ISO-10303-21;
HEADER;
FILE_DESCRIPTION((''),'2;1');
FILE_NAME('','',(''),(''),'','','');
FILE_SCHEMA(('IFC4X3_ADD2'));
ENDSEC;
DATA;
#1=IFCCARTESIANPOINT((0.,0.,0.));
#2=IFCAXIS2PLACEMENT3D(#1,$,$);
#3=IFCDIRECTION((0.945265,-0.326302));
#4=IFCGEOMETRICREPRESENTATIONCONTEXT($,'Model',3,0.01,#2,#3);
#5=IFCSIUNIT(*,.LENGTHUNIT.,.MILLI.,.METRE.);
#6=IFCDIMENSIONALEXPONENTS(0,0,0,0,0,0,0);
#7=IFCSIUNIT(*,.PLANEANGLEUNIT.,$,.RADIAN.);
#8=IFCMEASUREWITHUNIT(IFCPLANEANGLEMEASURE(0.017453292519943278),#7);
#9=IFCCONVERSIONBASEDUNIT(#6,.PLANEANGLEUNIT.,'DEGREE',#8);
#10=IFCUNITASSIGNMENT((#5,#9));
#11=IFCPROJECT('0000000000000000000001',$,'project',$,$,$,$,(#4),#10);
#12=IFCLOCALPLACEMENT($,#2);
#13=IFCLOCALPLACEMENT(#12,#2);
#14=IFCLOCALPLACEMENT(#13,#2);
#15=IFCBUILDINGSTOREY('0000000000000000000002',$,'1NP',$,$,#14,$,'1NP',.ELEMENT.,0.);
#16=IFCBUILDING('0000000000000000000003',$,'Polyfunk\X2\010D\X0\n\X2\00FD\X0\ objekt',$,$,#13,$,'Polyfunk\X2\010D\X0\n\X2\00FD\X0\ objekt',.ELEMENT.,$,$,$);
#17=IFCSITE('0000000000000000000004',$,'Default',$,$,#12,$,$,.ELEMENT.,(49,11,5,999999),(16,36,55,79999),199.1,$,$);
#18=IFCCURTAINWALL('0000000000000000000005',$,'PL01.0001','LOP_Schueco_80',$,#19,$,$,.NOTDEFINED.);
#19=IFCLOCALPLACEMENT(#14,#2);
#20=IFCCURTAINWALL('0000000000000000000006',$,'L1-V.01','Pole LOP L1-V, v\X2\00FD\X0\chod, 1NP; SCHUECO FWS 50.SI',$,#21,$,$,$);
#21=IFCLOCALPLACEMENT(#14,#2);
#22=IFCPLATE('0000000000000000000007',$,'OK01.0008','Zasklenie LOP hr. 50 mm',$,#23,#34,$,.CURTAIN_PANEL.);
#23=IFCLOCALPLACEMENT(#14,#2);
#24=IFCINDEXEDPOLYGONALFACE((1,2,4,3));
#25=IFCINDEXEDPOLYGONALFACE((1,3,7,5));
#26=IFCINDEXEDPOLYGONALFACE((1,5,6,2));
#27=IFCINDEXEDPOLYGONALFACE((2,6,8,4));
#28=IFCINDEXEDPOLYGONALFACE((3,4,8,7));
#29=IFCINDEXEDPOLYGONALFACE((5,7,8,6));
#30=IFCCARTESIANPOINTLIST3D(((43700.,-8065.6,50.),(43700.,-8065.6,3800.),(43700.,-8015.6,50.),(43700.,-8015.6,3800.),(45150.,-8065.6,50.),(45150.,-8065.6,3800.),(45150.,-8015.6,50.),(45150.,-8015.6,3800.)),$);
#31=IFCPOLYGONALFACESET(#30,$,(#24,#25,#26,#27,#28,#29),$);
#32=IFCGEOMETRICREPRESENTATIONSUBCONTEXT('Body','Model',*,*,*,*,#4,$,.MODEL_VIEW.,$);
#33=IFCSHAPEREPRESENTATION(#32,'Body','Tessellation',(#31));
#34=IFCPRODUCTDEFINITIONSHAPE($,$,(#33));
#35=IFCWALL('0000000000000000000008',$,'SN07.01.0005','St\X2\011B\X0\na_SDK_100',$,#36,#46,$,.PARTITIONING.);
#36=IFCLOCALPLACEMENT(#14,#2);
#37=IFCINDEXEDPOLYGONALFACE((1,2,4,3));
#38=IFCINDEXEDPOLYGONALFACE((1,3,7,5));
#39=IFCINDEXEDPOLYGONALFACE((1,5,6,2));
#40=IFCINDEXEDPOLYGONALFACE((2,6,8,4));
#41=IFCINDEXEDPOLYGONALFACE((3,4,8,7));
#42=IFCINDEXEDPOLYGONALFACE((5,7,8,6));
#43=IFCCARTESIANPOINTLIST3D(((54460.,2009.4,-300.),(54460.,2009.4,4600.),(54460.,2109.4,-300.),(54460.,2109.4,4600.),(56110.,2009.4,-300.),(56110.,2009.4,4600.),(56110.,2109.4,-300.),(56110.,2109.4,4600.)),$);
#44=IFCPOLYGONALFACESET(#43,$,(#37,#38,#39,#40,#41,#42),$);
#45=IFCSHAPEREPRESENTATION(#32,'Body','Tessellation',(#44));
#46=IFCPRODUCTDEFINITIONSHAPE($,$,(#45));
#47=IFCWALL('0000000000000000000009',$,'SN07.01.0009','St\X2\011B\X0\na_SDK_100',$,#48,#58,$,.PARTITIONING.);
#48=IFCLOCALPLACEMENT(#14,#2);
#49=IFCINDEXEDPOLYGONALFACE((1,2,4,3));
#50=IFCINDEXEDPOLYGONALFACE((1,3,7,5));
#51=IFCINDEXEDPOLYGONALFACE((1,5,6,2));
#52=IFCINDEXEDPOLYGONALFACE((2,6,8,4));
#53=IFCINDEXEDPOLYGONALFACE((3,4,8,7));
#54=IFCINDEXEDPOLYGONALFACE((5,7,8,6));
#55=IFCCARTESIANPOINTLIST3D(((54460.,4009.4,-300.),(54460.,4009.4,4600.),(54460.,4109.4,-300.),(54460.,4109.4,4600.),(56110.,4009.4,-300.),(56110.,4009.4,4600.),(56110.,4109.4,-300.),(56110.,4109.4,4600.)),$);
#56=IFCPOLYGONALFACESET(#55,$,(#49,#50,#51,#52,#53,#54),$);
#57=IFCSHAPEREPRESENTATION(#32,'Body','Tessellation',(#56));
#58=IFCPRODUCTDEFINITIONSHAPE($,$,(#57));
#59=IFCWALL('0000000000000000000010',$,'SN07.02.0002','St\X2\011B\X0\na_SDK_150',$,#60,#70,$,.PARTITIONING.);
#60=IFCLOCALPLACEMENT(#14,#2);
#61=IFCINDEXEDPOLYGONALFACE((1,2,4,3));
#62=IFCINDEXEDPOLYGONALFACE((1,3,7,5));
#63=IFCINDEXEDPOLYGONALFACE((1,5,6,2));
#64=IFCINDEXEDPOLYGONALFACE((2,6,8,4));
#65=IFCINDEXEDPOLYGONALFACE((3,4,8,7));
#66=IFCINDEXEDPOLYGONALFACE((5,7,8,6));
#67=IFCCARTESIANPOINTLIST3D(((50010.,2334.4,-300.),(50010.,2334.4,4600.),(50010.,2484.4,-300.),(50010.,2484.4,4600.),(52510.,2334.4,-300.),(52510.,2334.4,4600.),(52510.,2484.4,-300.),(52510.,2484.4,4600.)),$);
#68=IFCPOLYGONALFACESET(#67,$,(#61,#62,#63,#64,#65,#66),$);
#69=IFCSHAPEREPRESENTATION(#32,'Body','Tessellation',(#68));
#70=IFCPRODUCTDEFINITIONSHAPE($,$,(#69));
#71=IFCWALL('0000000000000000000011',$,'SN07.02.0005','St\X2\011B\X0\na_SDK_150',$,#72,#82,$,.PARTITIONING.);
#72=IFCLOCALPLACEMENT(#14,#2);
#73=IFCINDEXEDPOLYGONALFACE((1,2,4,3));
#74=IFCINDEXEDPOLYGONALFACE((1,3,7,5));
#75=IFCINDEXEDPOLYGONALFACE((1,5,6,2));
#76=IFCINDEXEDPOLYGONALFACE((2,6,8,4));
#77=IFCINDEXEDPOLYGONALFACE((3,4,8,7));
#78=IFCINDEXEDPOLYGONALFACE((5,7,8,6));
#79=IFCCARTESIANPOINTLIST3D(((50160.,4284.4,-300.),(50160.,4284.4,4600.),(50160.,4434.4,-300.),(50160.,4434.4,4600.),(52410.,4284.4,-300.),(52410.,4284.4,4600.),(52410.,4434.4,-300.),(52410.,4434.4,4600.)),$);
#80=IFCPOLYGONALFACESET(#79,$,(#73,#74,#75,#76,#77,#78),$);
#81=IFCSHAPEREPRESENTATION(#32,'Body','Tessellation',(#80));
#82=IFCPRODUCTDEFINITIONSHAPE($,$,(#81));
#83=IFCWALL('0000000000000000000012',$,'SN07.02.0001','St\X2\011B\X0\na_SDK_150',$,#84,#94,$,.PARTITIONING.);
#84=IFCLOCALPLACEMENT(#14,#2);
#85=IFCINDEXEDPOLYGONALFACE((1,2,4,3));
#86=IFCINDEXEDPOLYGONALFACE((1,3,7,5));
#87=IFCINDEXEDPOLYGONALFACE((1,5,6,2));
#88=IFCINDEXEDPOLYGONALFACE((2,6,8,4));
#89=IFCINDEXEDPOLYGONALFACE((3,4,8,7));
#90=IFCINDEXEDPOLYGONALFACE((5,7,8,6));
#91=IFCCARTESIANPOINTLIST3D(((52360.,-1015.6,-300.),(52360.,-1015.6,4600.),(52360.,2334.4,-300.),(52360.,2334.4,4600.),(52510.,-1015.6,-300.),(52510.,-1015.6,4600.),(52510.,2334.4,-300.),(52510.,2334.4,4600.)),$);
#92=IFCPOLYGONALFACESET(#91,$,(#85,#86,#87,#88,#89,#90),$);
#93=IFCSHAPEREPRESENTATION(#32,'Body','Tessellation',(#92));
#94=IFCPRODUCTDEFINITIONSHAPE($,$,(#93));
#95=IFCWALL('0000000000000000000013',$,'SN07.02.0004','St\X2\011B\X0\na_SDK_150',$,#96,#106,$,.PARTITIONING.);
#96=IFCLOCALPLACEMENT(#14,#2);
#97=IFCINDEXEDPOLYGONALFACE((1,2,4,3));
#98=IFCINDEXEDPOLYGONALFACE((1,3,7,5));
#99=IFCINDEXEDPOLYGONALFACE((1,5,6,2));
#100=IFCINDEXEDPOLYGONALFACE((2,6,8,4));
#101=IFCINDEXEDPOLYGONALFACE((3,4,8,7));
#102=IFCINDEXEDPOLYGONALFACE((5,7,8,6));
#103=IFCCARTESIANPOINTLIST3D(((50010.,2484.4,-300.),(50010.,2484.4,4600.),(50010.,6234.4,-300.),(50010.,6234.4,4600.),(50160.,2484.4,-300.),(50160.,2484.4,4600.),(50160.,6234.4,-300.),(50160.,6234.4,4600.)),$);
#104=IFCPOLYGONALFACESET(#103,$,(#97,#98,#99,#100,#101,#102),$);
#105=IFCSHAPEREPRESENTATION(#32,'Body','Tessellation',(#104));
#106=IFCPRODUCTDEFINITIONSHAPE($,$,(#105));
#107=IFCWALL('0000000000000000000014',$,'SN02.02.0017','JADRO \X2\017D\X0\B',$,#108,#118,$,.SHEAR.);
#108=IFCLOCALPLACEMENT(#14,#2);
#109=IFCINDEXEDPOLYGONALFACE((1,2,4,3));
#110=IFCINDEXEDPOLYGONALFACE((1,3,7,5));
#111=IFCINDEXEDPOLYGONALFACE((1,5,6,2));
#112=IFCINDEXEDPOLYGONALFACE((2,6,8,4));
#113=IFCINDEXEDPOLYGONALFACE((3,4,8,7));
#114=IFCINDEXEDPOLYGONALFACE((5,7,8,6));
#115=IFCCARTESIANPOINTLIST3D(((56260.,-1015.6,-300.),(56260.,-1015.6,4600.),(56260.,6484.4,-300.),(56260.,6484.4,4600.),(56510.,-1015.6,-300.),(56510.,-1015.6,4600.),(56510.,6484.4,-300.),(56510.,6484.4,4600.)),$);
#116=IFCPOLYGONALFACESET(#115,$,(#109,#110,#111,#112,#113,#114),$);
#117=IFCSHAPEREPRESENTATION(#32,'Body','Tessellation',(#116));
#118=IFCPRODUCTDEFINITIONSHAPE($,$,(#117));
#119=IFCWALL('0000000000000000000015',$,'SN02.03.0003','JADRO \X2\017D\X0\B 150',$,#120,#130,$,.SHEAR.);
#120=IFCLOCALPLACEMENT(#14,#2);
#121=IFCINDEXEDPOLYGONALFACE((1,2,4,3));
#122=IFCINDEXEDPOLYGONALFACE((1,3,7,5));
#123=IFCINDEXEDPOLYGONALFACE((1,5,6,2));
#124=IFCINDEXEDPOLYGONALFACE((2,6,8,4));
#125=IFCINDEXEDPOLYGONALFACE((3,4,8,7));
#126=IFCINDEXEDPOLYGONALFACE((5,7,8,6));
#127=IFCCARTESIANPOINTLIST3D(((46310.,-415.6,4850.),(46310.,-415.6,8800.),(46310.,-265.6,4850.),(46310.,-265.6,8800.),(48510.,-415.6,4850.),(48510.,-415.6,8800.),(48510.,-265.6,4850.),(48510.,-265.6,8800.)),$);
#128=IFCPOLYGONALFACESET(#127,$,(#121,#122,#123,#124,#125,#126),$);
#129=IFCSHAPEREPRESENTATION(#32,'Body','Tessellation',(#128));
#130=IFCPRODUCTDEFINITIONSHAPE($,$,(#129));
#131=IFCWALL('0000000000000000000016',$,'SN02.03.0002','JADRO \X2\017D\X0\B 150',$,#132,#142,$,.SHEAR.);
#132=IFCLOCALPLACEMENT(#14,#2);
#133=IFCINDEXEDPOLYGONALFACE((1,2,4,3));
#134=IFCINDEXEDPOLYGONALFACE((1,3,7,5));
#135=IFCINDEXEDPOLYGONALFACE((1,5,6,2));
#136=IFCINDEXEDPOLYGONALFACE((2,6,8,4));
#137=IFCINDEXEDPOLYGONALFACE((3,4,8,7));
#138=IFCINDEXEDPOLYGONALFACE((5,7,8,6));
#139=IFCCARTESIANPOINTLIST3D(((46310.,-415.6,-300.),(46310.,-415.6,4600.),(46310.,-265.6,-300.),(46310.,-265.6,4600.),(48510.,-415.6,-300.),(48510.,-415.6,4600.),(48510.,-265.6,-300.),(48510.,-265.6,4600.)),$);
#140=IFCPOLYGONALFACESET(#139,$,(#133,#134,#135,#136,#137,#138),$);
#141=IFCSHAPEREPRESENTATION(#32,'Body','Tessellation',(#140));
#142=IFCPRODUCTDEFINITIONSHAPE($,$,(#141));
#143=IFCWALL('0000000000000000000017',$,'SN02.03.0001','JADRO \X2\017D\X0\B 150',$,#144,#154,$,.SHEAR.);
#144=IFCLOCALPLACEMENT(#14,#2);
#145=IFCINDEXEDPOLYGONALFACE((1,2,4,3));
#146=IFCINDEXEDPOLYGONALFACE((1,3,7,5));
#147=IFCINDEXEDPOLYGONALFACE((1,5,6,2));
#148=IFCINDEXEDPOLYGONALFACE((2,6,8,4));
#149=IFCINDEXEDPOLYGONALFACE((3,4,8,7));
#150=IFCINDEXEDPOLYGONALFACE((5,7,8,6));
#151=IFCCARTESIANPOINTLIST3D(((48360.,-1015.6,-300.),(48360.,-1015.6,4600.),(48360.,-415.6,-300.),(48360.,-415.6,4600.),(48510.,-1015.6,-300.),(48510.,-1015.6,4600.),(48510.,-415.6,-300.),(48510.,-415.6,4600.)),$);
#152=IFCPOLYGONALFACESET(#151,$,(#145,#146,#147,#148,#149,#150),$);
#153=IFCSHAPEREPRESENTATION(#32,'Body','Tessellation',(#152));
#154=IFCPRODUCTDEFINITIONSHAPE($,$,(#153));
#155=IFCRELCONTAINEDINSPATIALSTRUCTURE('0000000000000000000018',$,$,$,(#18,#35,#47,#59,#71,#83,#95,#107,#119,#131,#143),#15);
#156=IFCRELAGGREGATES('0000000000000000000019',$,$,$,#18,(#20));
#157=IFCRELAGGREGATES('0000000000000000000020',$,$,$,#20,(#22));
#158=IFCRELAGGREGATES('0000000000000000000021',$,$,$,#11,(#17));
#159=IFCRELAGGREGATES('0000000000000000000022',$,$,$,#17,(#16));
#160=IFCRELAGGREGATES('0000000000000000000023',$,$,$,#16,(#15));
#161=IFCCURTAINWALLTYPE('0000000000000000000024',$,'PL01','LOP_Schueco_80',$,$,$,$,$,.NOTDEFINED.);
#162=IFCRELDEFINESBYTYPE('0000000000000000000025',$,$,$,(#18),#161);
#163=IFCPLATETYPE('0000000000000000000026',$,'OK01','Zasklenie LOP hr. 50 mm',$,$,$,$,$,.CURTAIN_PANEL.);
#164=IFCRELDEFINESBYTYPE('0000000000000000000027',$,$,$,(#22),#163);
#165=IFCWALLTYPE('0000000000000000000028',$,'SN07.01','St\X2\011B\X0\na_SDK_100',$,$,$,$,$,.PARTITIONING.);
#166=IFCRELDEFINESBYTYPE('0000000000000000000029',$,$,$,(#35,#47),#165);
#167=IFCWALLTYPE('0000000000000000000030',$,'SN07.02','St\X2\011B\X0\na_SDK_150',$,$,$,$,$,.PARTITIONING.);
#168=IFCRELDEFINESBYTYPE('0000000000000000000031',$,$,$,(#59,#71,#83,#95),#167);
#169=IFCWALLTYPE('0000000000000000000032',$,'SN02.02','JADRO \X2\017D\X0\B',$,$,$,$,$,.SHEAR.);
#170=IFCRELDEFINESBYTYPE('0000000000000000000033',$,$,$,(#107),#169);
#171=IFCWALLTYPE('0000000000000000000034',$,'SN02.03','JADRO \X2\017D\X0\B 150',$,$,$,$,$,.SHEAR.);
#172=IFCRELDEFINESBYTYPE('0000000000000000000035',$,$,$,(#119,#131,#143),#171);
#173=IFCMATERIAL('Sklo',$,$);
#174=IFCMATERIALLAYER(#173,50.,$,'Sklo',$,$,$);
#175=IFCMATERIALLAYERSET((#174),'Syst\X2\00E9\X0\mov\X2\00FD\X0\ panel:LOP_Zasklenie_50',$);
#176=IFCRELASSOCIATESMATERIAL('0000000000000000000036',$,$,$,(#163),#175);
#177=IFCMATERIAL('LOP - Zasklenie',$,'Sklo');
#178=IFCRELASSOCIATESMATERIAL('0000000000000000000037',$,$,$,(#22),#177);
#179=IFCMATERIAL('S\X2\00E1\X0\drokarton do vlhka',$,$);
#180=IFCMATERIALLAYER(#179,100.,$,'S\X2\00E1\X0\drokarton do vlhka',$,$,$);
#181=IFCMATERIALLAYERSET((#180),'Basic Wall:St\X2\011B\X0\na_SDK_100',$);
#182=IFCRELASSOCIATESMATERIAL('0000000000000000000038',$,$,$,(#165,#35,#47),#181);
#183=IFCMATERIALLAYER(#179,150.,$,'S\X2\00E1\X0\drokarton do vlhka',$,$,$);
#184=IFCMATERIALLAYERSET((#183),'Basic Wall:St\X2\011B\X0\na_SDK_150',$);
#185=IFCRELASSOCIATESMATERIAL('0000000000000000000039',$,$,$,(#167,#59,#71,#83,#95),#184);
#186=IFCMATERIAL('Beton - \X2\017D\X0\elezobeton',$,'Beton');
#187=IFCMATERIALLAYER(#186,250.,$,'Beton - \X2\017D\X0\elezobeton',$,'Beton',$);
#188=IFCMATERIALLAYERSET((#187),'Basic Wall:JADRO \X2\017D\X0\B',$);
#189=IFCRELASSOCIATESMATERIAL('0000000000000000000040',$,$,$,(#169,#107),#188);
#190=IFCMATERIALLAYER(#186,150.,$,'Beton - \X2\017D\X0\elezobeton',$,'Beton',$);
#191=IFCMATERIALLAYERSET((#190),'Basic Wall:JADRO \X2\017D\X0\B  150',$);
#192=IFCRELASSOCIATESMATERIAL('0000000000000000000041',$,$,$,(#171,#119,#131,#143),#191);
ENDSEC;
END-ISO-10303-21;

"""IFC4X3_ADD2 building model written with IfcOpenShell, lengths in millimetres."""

from ifc_helpers import new_model, entity, si_unit, converted_unit, direction, frame, frame_2d, origin, place, context, subcontext, project, spatial, polyline, rectangle, extrude, clip, bounded_halfspace, source, transform, mapped, material, layer, layer_set, type_object, type_shapes, element, aggregate, save


model = new_model("IFC4X3_ADD2")

# Units and contexts
model_context = context("Model", 3, precision=0.01, world=origin(), true_north=direction((0.945265, -0.326302)))
body_context = subcontext(model_context, "Body", "Model", "MODEL_VIEW")
ifc_project = project(units=[si_unit("LENGTHUNIT", "METRE", prefix="MILLI"), converted_unit("PLANEANGLEUNIT", "DEGREE", entity("IfcPlaneAngleMeasure", 0.017453292519943278), si_unit("PLANEANGLEUNIT", "RADIAN"), dimensions=[0, 0, 0, 0, 0, 0, 0])], contexts=[model_context])

# Site, building, storey
site_placement = place(None, origin())
site = spatial("IfcSite", under=ifc_project, at=site_placement, Name="Default", CompositionType="ELEMENT", RefLatitude=(49, 11, 5, 999999), RefLongitude=(16, 36, 55, 79999), RefElevation=199.1)
building_placement = place(site_placement, origin())
building = spatial("IfcBuilding", under=site, at=building_placement, Name="Polyfunkčný objekt", LongName="Polyfunkčný objekt", CompositionType="ELEMENT")
storey_placement = place(building_placement, origin())
storey = spatial("IfcBuildingStorey", under=building, at=storey_placement, Name="1NP", LongName="1NP", CompositionType="ELEMENT", Elevation=0.0)

# Curtain walls, plate
curtain_wall_type = type_object("IfcCurtainWallType", Name="PL01", Description="LOP_Schueco_80", PredefinedType="NOTDEFINED")
curtain_wall_1_placement = place(storey_placement, origin())
curtain_wall_1 = element("IfcCurtainWall", 1, at=curtain_wall_1_placement, inside=storey, type_object=curtain_wall_type, Name="PL01.0001", Description="LOP_Schueco_80", PredefinedType="NOTDEFINED")
curtain_wall_2 = element("IfcCurtainWall", 2, Name="L1-V.01", Description="Pole LOP L1-V, východ, 1NP; SCHUECO FWS 50.SI")
aggregate(curtain_wall_1, [curtain_wall_2])
ifc_material_1 = material(Name="LOP - Zasklenie", Category="Sklo")
ifc_material_2 = material(Name="Sklo")
ifc_layer_1 = layer(ifc_material_2, 50.0, Name="Sklo")
ifc_layer_set_1 = layer_set([ifc_layer_1], Name="Systémový panel:LOP_Zasklenie_50")
plate_type = type_object("IfcPlateType", Name="OK01", Description="Zasklenie LOP hr. 50 mm", PredefinedType="CURTAIN_PANEL", material=ifc_layer_set_1)
shared_shape_1 = source(origin(), body_context, "Body", "SweptSolid", [
    extrude(rectangle(XDim=3750.0, YDim=1450.0, at=frame_2d((-331.2, 0.0), x_axis=(1.0, 0.0))), frame((0.0, -50.0, 2206.2), z_axis=(0.0, 1.0, 0.0), x_axis=(0.0, 0.0, 1.0)), (0.0, 0.0, 1.0), 50.0),
])
type_shapes(plate_type, [shared_shape_1])
plate_placement = place(curtain_wall_1_placement, frame((44425.0, -8015.6, 50.0)))
plate = element("IfcPlate", 3, at=plate_placement, type_object=plate_type, material=ifc_material_1, Name="OK01.0008", Description="Zasklenie LOP hr. 50 mm", PredefinedType="CURTAIN_PANEL", context=body_context, shape_type="MappedRepresentation", body=[
    mapped(shared_shape_1, transform((0.0, 0.0, 0.0), scale=1.0)),
])
aggregate(curtain_wall_2, [plate])

# Walls
ifc_material_3 = material(Name="Sádrokarton do vlhka")
ifc_layer_2 = layer(ifc_material_3, 100.0, Name="Sádrokarton do vlhka")
ifc_layer_set_2 = layer_set([ifc_layer_2], Name="Basic Wall:Stěna_SDK_100")
wall_type_1 = type_object("IfcWallType", Name="SN07.01", Description="Stěna_SDK_100", PredefinedType="PARTITIONING", material=ifc_layer_set_2)
wall_1_placement = place(storey_placement, frame((54460.0, 2059.4, -300.0)))
element("IfcWall", 4, at=wall_1_placement, inside=storey, type_object=wall_type_1, material=ifc_layer_set_2, Name="SN07.01.0005", Description="Stěna_SDK_100", PredefinedType="PARTITIONING", context=body_context, shape_type="Clipping", body=[
    clip(clip(extrude(rectangle(XDim=1650.0, YDim=100.0, at=frame_2d((825.0, 0.0), x_axis=(-1.0, 0.0))), origin(), (0.0, 0.0, 1.0), 4900.0), bounded_halfspace(frame((0.0, -50.0, 4900.0), z_axis=(0.0, 0.0, -1.0), x_axis=(1.0, 0.0, 0.0)), True, frame((0.0, -50.0, 4900.0)), polyline([(0.0, 0.0), (1650.0, 0.0), (1650.0, 100.0), (0.0, 100.0), (0.0, 0.0)]))), bounded_halfspace(frame((1650.0, -50.0, 0.0), z_axis=(0.0, 0.0, 1.0), x_axis=(0.0, 1.0, 0.0)), True, frame((1650.0, -50.0, 0.0)), polyline([(0.0, 0.0), (0.0, 100.0), (-1650.0, 100.0), (-1650.0, 0.0), (0.0, 0.0)]))),
])
wall_2_placement = place(storey_placement, frame((54460.0, 4059.4, -300.0)))
element("IfcWall", 5, at=wall_2_placement, inside=storey, type_object=wall_type_1, material=ifc_layer_set_2, Name="SN07.01.0009", Description="Stěna_SDK_100", PredefinedType="PARTITIONING", context=body_context, shape_type="Clipping", body=[
    clip(clip(extrude(rectangle(XDim=1650.0, YDim=100.0, at=frame_2d((825.0, 0.0), x_axis=(-1.0, 0.0))), origin(), (0.0, 0.0, 1.0), 4900.0), bounded_halfspace(frame((0.0, -50.0, 4900.0), z_axis=(0.0, 0.0, -1.0), x_axis=(1.0, 0.0, 0.0)), True, frame((0.0, -50.0, 4900.0)), polyline([(0.0, 0.0), (1650.0, 0.0), (1650.0, 100.0), (0.0, 100.0), (0.0, 0.0)]))), bounded_halfspace(frame((1650.0, -50.0, 0.0), z_axis=(0.0, 0.0, 1.0), x_axis=(0.0, 1.0, 0.0)), True, frame((1650.0, -50.0, 0.0)), polyline([(0.0, 0.0), (0.0, 100.0), (-1650.0, 100.0), (-1650.0, 0.0), (0.0, 0.0)]))),
])
ifc_layer_3 = layer(ifc_material_3, 150.0, Name="Sádrokarton do vlhka")
ifc_layer_set_3 = layer_set([ifc_layer_3], Name="Basic Wall:Stěna_SDK_150")
wall_type_2 = type_object("IfcWallType", Name="SN07.02", Description="Stěna_SDK_150", PredefinedType="PARTITIONING", material=ifc_layer_set_3)
wall_3_placement = place(storey_placement, frame((50010.0, 2409.4, -300.0)))
element("IfcWall", 6, at=wall_3_placement, inside=storey, type_object=wall_type_2, material=ifc_layer_set_3, Name="SN07.02.0002", Description="Stěna_SDK_150", PredefinedType="PARTITIONING", context=body_context, shape_type="Clipping", body=[
    clip(clip(extrude(rectangle(XDim=2500.0, YDim=150.0, at=frame_2d((1250.0, 0.0), x_axis=(-1.0, 0.0))), origin(), (0.0, 0.0, 1.0), 4900.0), bounded_halfspace(frame((2500.0, -75.0, 0.0), z_axis=(0.0, 0.0, 1.0), x_axis=(0.0, 1.0, 0.0)), True, frame((2500.0, -75.0, 0.0)), polyline([(0.0, 0.0), (0.0, 150.0), (-100.0, 150.0), (-2350.0, 150.0), (-2500.0, 150.0), (-2500.0, 0.0), (-150.0, 0.0), (0.0, 0.0)]))), bounded_halfspace(frame((0.0, -75.0, 4900.0), z_axis=(0.0, 0.0, -1.0), x_axis=(1.0, 0.0, 0.0)), True, frame((0.0, -75.0, 4900.0)), polyline([(0.0, 0.0), (2350.0, 0.0), (2500.0, 0.0), (2500.0, 150.0), (2400.0, 150.0), (150.0, 150.0), (0.0, 150.0), (0.0, 0.0)]))),
])
wall_4_placement = place(storey_placement, frame((50160.0, 4359.4, -300.0)))
element("IfcWall", 7, at=wall_4_placement, inside=storey, type_object=wall_type_2, material=ifc_layer_set_3, Name="SN07.02.0005", Description="Stěna_SDK_150", PredefinedType="PARTITIONING", context=body_context, shape_type="Clipping", body=[
    clip(clip(extrude(rectangle(XDim=2250.0, YDim=150.0, at=frame_2d((1125.0, 0.0), x_axis=(-1.0, 0.0))), origin(), (0.0, 0.0, 1.0), 4900.0), bounded_halfspace(frame((2250.0, -75.0, 0.0), z_axis=(0.0, 0.0, 1.0), x_axis=(0.0, 1.0, 0.0)), True, frame((2250.0, -75.0, 0.0)), polyline([(0.0, 0.0), (0.0, 150.0), (-2250.0, 150.0), (-2250.0, 0.0), (0.0, 0.0)]))), bounded_halfspace(frame((0.0, -75.0, 4900.0), z_axis=(0.0, 0.0, -1.0), x_axis=(1.0, 0.0, 0.0)), True, frame((0.0, -75.0, 4900.0)), polyline([(0.0, 0.0), (2250.0, 0.0), (2250.0, 150.0), (0.0, 150.0), (0.0, 0.0)]))),
])
wall_5_placement = place(storey_placement, frame((52435.0, 2334.4, -300.0), z_axis=(0.0, 0.0, 1.0), x_axis=(0.0, -1.0, 0.0)))
element("IfcWall", 8, at=wall_5_placement, inside=storey, type_object=wall_type_2, material=ifc_layer_set_3, Name="SN07.02.0001", Description="Stěna_SDK_150", PredefinedType="PARTITIONING", context=body_context, shape_type="Clipping", body=[
    clip(clip(extrude(rectangle(XDim=3350.0, YDim=150.0, at=frame_2d((1675.0, 0.0), x_axis=(-1.0, 0.0))), origin(), (0.0, 0.0, 1.0), 4900.0), bounded_halfspace(frame((3350.0, -75.0, 0.0), z_axis=(0.0, 0.0, 1.0), x_axis=(-1.0, 0.0, 0.0)), True, frame((3350.0, -75.0, 0.0)), polyline([(0.0, 0.0), (0.0, 150.0), (-3350.0, 150.0), (-3350.0, 0.0), (0.0, 0.0)]))), bounded_halfspace(frame((0.0, -75.0, 4900.0), z_axis=(0.0, 0.0, -1.0), x_axis=(0.0, 1.0, 0.0)), True, frame((0.0, -75.0, 4900.0)), polyline([(0.0, 0.0), (3350.0, 0.0), (3350.0, 150.0), (0.0, 150.0), (0.0, 0.0)]))),
])
wall_6_placement = place(storey_placement, frame((50085.0, 2484.4, -300.0), z_axis=(0.0, 0.0, 1.0), x_axis=(0.0, 1.0, 0.0)))
element("IfcWall", 9, at=wall_6_placement, inside=storey, type_object=wall_type_2, material=ifc_layer_set_3, Name="SN07.02.0004", Description="Stěna_SDK_150", PredefinedType="PARTITIONING", context=body_context, shape_type="Clipping", body=[
    clip(clip(extrude(rectangle(XDim=3750.0, YDim=150.0, at=frame_2d((1875.0, 0.0), x_axis=(-1.0, 0.0))), origin(), (0.0, 0.0, 1.0), 4900.0), bounded_halfspace(frame((0.0, -75.0, 4900.0), z_axis=(0.0, 0.0, -1.0), x_axis=(0.0, -1.0, 0.0)), True, frame((0.0, -75.0, 4900.0)), polyline([(0.0, 0.0), (1800.0, 0.0), (1950.0, 0.0), (3750.0, 0.0), (3750.0, 150.0), (0.0, 150.0), (0.0, 0.0)]))), bounded_halfspace(frame((3750.0, -75.0, 0.0)), True, frame((3750.0, -75.0, 0.0)), polyline([(0.0, 0.0), (0.0, 150.0), (-3750.0, 150.0), (-3750.0, 0.0), (-1950.0, 0.0), (-1800.0, 0.0), (0.0, 0.0)]))),
])
ifc_material_4 = material(Name="Beton - Železobeton", Category="Beton")
ifc_layer_4 = layer(ifc_material_4, 250.0, Name="Beton - Železobeton", Category="Beton")
ifc_layer_set_4 = layer_set([ifc_layer_4], Name="Basic Wall:JADRO ŽB")
wall_type_3 = type_object("IfcWallType", Name="SN02.02", Description="JADRO ŽB", PredefinedType="SHEAR", material=ifc_layer_set_4)
wall_7_placement = place(storey_placement, frame((56385.0, -1015.6, -300.0), z_axis=(0.0, 0.0, 1.0), x_axis=(0.0, 1.0, 0.0)))
element("IfcWall", 10, at=wall_7_placement, inside=storey, type_object=wall_type_3, material=ifc_layer_set_4, Name="SN02.02.0017", Description="JADRO ŽB", PredefinedType="SHEAR", context=body_context, shape_type="Clipping", body=[
    clip(clip(extrude(rectangle(XDim=7500.0, YDim=250.0, at=frame_2d((3750.0, 0.0), x_axis=(-1.0, 0.0))), origin(), (0.0, 0.0, 1.0), 4900.0), bounded_halfspace(frame((0.0, -125.0, 4900.0), z_axis=(0.0, 0.0, -1.0), x_axis=(0.0, -1.0, 0.0)), True, frame((0.0, -125.0, 4900.0)), polyline([(0.0, 0.0), (7500.0, 0.0), (7500.0, 250.0), (7250.0, 250.0), (0.0, 250.0), (0.0, 0.0)]))), bounded_halfspace(frame((0.0, -125.0, 0.0)), True, frame((0.0, -125.0, 0.0)), polyline([(0.0, 0.0), (7110.0, 0.0), (7500.0, 0.0), (7500.0, 250.0), (7250.0, 250.0), (0.0, 250.0), (0.0, 0.0)]))),
])
ifc_layer_5 = layer(ifc_material_4, 150.0, Name="Beton - Železobeton", Category="Beton")
ifc_layer_set_5 = layer_set([ifc_layer_5], Name="Basic Wall:JADRO ŽB  150")
wall_type_4 = type_object("IfcWallType", Name="SN02.03", Description="JADRO ŽB 150", PredefinedType="SHEAR", material=ifc_layer_set_5)
wall_8_placement = place(storey_placement, frame((46310.0, -340.6, 4850.0)))
element("IfcWall", 11, at=wall_8_placement, inside=storey, type_object=wall_type_4, material=ifc_layer_set_5, Name="SN02.03.0003", Description="JADRO ŽB 150", PredefinedType="SHEAR", context=body_context, shape_type="Clipping", body=[
    clip(clip(extrude(rectangle(XDim=2200.0, YDim=150.0, at=frame_2d((1100.0, 0.0), x_axis=(-1.0, 0.0))), origin(), (0.0, 0.0, 1.0), 3950.0), bounded_halfspace(frame((2200.0, -75.0, 0.0), z_axis=(0.0, 0.0, 1.0), x_axis=(-1.0, 0.0, 0.0)), True, frame((2200.0, -75.0, 0.0)), polyline([(0.0, 0.0), (0.0, 150.0), (-2200.0, 150.0), (-2200.0, 0.0), (0.0, 0.0)]))), bounded_halfspace(frame((0.0, -75.0, 3950.0), z_axis=(0.0, 0.0, -1.0), x_axis=(1.0, 0.0, 0.0)), True, frame((0.0, -75.0, 3950.0)), polyline([(0.0, 0.0), (2050.0, 0.0), (2200.0, 0.0), (2200.0, 150.0), (0.0, 150.0), (0.0, 0.0)]))),
])
wall_9_placement = place(storey_placement, frame((46310.0, -340.6, -300.0)))
element("IfcWall", 12, at=wall_9_placement, inside=storey, type_object=wall_type_4, material=ifc_layer_set_5, Name="SN02.03.0002", Description="JADRO ŽB 150", PredefinedType="SHEAR", context=body_context, shape_type="SweptSolid", body=[
    extrude(rectangle(XDim=2200.0, YDim=150.0, at=frame_2d((1100.0, 0.0), x_axis=(-1.0, 0.0))), origin(), (0.0, 0.0, 1.0), 4900.0),
])
wall_10_placement = place(storey_placement, frame((48435.0, -1015.6, -300.0), z_axis=(0.0, 0.0, 1.0), x_axis=(0.0, 1.0, 0.0)))
element("IfcWall", 13, at=wall_10_placement, inside=storey, type_object=wall_type_4, material=ifc_layer_set_5, Name="SN02.03.0001", Description="JADRO ŽB 150", PredefinedType="SHEAR", context=body_context, shape_type="SweptSolid", body=[
    extrude(rectangle(XDim=600.0, YDim=150.0, at=frame_2d((300.0, 0.0), x_axis=(-1.0, 0.0))), origin(), (0.0, 0.0, 1.0), 4900.0),
])

save(model, "model.ifc")
